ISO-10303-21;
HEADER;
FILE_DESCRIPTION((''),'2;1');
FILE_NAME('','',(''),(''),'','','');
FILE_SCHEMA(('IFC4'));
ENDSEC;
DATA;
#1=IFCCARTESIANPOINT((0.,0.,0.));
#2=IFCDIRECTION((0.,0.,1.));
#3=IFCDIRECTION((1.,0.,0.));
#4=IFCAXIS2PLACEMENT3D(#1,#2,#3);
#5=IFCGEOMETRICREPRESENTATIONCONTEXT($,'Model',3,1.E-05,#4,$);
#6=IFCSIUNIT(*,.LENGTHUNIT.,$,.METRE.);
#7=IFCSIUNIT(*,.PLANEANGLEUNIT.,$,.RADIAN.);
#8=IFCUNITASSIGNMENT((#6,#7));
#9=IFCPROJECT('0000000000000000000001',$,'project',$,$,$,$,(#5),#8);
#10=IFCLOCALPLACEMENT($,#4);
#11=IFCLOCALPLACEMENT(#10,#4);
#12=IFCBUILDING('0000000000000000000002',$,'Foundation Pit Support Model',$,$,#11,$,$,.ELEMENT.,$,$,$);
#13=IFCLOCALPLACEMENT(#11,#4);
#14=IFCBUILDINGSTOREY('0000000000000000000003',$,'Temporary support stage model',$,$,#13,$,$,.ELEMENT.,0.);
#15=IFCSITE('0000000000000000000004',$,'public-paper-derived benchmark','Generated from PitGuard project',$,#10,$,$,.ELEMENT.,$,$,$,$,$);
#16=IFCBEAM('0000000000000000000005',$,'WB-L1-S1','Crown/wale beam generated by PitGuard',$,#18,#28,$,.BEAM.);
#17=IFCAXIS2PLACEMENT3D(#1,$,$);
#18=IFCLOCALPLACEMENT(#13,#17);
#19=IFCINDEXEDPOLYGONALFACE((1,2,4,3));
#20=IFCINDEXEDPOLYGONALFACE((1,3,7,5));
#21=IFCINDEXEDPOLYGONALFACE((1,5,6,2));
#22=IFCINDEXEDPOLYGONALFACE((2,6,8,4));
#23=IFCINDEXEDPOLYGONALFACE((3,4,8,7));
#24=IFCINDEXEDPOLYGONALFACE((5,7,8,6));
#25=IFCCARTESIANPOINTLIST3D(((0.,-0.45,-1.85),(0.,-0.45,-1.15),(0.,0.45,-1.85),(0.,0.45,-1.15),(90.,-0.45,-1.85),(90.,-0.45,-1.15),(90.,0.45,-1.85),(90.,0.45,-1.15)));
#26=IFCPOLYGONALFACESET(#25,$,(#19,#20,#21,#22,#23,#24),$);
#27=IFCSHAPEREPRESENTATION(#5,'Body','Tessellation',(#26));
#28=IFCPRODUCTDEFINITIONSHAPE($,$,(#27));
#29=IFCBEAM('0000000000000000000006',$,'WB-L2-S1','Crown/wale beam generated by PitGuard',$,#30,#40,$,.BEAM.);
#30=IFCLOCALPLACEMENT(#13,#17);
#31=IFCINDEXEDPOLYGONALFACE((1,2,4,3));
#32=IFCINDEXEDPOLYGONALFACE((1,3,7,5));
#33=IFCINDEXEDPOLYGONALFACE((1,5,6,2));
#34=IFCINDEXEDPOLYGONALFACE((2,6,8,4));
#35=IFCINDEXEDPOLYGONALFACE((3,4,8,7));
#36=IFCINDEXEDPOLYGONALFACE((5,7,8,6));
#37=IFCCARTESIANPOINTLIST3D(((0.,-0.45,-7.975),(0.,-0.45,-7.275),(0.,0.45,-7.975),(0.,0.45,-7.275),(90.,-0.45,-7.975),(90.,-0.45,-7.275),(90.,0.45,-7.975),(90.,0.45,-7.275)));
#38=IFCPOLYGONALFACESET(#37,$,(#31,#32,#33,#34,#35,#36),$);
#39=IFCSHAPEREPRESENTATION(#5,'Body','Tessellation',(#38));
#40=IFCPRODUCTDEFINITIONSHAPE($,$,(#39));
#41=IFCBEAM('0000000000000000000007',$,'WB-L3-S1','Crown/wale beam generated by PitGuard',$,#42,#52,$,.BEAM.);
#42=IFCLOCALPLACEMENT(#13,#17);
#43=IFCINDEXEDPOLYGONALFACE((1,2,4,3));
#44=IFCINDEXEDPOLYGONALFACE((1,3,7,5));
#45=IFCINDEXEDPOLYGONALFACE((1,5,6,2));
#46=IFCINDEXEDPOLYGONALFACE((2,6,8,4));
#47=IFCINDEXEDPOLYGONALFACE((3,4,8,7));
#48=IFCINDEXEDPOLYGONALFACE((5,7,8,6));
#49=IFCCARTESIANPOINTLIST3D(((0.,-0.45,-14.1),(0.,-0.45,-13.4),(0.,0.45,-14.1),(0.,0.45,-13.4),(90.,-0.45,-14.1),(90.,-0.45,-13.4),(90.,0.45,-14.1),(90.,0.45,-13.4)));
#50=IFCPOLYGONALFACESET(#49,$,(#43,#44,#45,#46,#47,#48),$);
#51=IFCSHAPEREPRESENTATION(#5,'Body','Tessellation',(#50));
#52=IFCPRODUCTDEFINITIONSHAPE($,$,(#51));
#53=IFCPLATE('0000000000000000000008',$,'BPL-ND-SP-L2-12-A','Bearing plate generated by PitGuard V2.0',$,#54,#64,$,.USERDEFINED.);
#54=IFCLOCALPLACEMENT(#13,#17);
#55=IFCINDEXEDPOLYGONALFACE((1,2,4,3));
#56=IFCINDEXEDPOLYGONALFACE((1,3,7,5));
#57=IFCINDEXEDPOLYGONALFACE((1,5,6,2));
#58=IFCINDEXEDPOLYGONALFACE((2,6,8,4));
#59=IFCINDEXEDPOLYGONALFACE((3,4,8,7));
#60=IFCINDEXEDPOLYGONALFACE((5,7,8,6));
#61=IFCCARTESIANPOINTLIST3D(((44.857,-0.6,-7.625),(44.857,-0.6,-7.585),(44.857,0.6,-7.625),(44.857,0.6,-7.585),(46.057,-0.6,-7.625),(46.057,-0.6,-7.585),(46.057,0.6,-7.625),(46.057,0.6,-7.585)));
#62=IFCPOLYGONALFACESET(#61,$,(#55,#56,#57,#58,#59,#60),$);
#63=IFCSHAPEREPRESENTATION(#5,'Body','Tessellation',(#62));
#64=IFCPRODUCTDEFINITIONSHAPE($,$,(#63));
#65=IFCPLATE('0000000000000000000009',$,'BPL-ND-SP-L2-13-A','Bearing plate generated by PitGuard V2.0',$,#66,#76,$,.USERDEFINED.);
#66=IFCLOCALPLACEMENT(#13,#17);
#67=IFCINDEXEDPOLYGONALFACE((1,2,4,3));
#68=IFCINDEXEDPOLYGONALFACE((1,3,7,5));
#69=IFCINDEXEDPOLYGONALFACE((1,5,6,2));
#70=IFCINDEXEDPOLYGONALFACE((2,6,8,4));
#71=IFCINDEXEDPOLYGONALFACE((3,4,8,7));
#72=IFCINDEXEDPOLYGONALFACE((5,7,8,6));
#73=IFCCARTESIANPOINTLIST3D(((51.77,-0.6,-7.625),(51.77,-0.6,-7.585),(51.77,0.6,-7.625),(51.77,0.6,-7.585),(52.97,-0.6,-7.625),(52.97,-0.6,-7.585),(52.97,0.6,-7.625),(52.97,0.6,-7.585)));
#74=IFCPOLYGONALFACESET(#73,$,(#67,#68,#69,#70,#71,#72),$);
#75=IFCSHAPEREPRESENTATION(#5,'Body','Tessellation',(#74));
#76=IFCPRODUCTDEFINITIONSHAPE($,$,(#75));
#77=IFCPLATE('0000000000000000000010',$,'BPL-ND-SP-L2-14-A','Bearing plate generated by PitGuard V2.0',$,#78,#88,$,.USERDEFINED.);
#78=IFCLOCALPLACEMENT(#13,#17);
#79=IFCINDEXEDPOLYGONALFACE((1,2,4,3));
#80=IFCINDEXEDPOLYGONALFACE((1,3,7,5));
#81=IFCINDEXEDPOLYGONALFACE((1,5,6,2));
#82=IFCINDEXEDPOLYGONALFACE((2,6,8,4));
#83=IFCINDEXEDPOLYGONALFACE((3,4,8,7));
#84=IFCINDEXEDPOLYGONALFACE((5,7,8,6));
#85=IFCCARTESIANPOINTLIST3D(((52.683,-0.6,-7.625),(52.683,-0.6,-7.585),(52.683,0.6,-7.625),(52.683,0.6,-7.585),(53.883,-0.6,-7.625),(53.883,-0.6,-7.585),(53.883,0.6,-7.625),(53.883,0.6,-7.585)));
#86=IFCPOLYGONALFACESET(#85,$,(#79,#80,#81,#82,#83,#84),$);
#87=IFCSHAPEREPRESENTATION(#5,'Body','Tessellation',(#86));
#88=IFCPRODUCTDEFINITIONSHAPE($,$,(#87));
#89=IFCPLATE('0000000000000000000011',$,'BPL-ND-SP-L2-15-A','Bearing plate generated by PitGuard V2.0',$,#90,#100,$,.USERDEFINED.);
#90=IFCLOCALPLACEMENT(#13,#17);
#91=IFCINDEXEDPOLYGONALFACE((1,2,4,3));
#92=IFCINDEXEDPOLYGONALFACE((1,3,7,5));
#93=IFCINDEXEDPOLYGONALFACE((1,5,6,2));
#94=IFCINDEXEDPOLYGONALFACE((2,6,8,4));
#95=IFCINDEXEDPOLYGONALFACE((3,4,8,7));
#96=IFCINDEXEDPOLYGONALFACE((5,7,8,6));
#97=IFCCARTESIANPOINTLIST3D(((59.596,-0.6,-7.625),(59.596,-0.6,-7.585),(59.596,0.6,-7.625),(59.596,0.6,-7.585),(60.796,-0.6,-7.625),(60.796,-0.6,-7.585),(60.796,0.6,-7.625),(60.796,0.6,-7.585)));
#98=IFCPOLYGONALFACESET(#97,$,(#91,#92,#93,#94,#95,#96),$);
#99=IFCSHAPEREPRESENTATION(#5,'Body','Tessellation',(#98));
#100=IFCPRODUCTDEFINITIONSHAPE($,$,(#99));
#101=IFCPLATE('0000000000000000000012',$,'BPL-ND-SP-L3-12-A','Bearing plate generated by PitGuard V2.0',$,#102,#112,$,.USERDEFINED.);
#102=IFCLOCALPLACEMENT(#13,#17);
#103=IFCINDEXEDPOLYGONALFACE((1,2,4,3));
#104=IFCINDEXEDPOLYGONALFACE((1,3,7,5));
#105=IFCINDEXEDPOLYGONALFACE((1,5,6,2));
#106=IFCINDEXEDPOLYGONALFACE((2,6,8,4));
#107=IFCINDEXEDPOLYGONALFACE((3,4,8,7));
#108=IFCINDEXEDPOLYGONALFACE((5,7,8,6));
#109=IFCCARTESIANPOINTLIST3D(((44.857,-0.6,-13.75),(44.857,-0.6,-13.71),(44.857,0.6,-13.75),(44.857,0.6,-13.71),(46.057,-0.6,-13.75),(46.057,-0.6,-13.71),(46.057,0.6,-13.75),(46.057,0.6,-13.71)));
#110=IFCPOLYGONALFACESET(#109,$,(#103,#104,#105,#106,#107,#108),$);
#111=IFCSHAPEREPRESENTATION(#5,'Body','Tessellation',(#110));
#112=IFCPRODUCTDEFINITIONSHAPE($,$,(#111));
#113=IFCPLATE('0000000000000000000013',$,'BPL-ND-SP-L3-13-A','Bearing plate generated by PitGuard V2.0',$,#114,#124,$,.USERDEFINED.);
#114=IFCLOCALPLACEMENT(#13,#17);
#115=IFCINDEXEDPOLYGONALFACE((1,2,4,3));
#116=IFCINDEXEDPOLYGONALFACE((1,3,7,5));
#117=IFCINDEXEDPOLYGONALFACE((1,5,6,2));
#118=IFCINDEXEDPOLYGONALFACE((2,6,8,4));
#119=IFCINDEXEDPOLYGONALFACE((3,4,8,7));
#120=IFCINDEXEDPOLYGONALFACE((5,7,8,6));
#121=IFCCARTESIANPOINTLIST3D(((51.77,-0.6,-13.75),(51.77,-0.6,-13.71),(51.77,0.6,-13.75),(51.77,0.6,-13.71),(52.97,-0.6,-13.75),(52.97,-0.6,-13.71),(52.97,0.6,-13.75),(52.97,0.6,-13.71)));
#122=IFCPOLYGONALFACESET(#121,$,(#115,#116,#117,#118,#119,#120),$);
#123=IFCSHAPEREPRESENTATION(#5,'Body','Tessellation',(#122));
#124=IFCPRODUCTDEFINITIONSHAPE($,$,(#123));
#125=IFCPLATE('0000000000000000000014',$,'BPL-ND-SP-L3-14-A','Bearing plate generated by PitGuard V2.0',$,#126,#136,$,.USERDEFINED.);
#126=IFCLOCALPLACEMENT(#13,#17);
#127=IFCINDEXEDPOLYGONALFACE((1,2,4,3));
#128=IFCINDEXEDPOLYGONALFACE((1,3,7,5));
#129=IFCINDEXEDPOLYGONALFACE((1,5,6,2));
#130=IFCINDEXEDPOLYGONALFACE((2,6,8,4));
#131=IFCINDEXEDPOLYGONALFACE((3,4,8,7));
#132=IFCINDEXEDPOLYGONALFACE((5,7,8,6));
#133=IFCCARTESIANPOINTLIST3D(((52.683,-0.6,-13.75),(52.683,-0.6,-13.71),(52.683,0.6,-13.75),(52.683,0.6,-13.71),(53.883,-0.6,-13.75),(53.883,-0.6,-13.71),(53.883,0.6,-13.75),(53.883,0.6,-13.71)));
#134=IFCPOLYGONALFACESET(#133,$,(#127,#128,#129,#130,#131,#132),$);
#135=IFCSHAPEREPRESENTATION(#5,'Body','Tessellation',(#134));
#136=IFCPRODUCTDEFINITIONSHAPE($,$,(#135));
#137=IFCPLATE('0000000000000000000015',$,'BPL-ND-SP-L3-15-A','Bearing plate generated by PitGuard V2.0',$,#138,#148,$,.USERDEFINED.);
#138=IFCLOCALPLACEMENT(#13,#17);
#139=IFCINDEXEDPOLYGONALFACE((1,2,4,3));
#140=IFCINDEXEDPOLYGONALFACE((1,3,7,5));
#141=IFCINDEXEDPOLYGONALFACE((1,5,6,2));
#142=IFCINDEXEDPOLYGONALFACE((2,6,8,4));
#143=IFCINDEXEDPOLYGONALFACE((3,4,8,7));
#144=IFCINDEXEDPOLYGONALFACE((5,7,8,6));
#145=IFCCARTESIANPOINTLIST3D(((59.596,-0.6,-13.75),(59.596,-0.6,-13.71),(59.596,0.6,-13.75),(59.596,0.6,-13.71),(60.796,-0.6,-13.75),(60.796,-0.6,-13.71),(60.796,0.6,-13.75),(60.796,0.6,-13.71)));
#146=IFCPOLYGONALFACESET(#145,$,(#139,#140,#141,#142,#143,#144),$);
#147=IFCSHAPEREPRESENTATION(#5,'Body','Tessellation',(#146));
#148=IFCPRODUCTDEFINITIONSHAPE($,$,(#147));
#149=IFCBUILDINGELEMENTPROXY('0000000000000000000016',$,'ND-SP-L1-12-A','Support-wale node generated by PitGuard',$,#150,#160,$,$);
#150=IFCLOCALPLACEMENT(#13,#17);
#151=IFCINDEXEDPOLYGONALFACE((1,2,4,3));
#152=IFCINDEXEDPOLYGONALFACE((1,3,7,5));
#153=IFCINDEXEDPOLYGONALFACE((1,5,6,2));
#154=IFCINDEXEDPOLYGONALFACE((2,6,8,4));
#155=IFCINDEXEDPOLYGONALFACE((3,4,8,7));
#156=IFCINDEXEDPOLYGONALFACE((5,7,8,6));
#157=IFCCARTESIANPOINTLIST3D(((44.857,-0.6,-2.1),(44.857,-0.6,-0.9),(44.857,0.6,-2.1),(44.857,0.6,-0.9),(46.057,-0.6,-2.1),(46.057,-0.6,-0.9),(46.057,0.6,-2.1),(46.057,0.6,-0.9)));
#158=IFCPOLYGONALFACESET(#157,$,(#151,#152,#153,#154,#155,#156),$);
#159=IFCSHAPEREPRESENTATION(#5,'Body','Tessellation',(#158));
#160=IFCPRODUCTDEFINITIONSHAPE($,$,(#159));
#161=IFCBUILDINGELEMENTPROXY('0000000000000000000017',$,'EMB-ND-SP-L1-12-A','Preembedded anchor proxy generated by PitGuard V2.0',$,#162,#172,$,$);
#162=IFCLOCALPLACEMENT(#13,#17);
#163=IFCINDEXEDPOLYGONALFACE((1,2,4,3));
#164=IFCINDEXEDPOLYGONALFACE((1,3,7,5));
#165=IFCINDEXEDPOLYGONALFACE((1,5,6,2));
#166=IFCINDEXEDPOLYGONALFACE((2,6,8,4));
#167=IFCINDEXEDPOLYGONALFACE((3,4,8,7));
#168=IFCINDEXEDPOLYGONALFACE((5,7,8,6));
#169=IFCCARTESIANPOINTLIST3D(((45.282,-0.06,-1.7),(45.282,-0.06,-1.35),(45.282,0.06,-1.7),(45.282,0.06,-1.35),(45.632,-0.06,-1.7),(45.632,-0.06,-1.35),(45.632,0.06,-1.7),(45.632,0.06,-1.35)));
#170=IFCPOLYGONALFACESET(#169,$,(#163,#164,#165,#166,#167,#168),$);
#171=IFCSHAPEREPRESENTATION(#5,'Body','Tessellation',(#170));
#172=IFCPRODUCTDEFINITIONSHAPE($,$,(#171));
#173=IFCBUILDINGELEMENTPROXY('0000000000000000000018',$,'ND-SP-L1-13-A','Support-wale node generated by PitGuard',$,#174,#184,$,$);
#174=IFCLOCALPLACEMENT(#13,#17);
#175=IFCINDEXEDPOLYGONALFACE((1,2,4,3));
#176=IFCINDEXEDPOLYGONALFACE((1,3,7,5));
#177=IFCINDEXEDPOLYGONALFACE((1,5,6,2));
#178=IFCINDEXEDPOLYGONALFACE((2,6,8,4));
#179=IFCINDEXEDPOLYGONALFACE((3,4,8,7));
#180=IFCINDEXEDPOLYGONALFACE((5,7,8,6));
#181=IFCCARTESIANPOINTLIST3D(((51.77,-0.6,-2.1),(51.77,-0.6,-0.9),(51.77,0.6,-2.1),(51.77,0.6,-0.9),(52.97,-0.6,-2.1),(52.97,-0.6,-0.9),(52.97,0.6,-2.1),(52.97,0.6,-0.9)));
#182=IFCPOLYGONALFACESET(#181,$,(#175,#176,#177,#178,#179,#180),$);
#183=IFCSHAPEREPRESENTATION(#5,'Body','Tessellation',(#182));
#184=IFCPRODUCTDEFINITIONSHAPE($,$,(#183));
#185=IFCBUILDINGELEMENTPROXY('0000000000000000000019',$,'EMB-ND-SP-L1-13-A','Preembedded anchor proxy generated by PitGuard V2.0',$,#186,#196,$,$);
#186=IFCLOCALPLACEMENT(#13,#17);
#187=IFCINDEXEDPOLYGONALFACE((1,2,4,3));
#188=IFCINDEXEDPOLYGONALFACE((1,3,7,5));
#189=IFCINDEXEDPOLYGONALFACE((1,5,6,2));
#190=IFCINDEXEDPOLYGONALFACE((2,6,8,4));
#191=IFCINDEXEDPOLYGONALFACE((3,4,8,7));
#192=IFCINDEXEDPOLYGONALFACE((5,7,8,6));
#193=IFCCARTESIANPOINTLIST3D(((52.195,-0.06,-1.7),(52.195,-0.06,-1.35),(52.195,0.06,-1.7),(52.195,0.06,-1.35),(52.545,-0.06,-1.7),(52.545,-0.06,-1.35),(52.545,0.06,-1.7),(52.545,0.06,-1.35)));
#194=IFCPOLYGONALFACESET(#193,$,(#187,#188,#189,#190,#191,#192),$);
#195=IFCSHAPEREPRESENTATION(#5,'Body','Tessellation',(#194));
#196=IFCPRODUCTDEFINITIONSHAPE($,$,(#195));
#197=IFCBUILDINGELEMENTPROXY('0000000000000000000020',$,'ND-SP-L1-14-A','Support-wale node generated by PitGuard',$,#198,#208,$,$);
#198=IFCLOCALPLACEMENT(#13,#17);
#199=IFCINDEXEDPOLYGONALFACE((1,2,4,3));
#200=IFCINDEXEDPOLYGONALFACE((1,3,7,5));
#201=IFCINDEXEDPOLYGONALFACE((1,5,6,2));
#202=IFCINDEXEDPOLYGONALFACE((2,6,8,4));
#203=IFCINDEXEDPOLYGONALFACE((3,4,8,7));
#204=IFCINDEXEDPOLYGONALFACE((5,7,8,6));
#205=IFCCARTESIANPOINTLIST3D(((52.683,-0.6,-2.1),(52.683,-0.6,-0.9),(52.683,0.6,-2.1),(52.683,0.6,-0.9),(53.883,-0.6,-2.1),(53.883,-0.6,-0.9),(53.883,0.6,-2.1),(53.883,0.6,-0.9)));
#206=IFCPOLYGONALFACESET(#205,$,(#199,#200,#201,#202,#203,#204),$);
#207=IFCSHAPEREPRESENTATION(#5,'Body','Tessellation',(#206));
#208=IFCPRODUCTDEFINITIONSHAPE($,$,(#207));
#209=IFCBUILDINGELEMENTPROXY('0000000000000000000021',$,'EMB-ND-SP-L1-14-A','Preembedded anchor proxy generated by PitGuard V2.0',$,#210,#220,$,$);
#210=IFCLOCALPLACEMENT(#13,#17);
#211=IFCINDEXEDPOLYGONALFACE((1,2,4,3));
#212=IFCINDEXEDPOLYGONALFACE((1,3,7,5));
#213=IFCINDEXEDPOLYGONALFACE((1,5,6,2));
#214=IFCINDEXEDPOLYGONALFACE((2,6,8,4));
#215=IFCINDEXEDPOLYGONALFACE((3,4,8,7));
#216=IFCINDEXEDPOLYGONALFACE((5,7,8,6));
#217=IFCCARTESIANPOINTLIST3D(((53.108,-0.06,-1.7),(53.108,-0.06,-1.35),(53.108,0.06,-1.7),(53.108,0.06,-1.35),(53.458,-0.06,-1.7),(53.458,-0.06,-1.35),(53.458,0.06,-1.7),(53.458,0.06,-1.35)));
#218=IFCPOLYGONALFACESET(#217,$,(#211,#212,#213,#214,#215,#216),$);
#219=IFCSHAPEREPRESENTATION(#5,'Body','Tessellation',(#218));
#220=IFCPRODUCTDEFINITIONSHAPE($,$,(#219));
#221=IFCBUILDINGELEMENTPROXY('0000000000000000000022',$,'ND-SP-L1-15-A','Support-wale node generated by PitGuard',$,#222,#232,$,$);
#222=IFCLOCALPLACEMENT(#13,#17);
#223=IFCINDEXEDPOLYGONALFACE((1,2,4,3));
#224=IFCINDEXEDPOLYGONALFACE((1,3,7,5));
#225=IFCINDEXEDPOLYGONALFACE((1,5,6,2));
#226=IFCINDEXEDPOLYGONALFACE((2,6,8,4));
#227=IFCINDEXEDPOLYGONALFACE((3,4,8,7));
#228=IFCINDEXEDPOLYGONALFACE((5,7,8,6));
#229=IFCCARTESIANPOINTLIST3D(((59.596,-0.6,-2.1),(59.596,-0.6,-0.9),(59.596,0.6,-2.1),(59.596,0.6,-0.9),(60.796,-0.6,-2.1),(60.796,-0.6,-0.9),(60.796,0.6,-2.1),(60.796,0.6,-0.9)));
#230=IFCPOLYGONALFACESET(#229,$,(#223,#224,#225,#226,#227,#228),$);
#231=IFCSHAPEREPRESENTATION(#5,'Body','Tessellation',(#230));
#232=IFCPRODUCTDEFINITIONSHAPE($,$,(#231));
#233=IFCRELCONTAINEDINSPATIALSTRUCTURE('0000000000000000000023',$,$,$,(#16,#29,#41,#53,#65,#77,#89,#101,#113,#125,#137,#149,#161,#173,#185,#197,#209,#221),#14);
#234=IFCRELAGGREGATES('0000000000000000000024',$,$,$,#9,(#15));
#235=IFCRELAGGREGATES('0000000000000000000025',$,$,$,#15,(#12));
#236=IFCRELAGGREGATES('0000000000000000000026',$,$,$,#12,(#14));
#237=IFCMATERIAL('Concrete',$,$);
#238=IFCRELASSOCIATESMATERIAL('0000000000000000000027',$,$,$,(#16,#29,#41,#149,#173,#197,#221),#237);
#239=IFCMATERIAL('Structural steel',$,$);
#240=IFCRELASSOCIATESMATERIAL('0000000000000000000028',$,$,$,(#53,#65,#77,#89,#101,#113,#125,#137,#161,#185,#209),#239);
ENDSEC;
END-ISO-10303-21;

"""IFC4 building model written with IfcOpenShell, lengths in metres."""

from ifc_helpers import new_model, si_unit, frame, origin_with_axes, origin_2d, place, context, project, spatial, rectangle, extrude, material, element, save


model = new_model("IFC4")

# Units and contexts
model_context = context("Model", 3, precision=1e-05, world=origin_with_axes())
ifc_project = project(units=[si_unit("LENGTHUNIT", "METRE"), si_unit("PLANEANGLEUNIT", "RADIAN")], contexts=[model_context])

# Site, building, storey
site_placement = place(None, origin_with_axes())
site = spatial("IfcSite", under=ifc_project, at=site_placement, Name="public-paper-derived benchmark", Description="Generated from PitGuard project", CompositionType="ELEMENT")
building_placement = place(site_placement, origin_with_axes())
building = spatial("IfcBuilding", under=site, at=building_placement, Name="Foundation Pit Support Model", CompositionType="ELEMENT")
storey_placement = place(building_placement, origin_with_axes())
storey = spatial("IfcBuildingStorey", under=building, at=storey_placement, Name="Temporary support stage model", CompositionType="ELEMENT", Elevation=0.0)

# Beams
ifc_material_1 = material(Name="Concrete")
for number, where, z_axis, x_axis, name in (
    (1, (45.0, 0.0, -1.85), (0.0, 0.0, 1.0), (1.0, 0.0, 0.0), "WB-L1-S1"),
    (2, (45.0, 0.0, -7.975), (0.0, 0.0, 1.0), (1.0, 0.0, 0.0), "WB-L2-S1"),
    (3, (45.0, 0.0, -14.1), (0.0, 0.0, 1.0), (1.0, 0.0, 0.0), "WB-L3-S1"),
):
    element("IfcBeam", number, at=place(storey_placement, frame(where, z_axis=z_axis, x_axis=x_axis)), inside=storey, material=ifc_material_1, Name=name, Description="Crown/wale beam generated by PitGuard", PredefinedType="BEAM", context=model_context, shape_type="SweptSolid", body=[
        extrude(rectangle(XDim=90.0, YDim=0.9, at=origin_2d()), origin_with_axes(), (0.0, 0.0, 1.0), 0.7),
    ])

# Plates
ifc_material_2 = material(Name="Structural steel")
for number, where, z_axis, x_axis, name in (
    (4, (45.457, 0.0, -7.625), (0.0, 0.0, 1.0), (1.0, 0.0, 0.0), "BPL-ND-SP-L2-12-A"),
    (5, (52.37, 0.0, -7.625), (0.0, 0.0, 1.0), (1.0, 0.0, 0.0), "BPL-ND-SP-L2-13-A"),
    (6, (53.283, 0.0, -7.625), (0.0, 0.0, 1.0), (1.0, 0.0, 0.0), "BPL-ND-SP-L2-14-A"),
    (7, (60.196, 0.0, -7.625), (0.0, 0.0, 1.0), (1.0, 0.0, 0.0), "BPL-ND-SP-L2-15-A"),
    (8, (45.457, 0.0, -13.75), (0.0, 0.0, 1.0), (1.0, 0.0, 0.0), "BPL-ND-SP-L3-12-A"),
    (9, (52.37, 0.0, -13.75), (0.0, 0.0, 1.0), (1.0, 0.0, 0.0), "BPL-ND-SP-L3-13-A"),
    (10, (53.283, 0.0, -13.75), (0.0, 0.0, 1.0), (1.0, 0.0, 0.0), "BPL-ND-SP-L3-14-A"),
    (11, (60.196, 0.0, -13.75), (0.0, 0.0, 1.0), (1.0, 0.0, 0.0), "BPL-ND-SP-L3-15-A"),
):
    element("IfcPlate", number, at=place(storey_placement, frame(where, z_axis=z_axis, x_axis=x_axis)), inside=storey, material=ifc_material_2, Name=name, Description="Bearing plate generated by PitGuard V2.0", PredefinedType="USERDEFINED", context=model_context, shape_type="SweptSolid", body=[
        extrude(rectangle(XDim=1.2, YDim=1.2, at=origin_2d()), origin_with_axes(), (0.0, 0.0, 1.0), 0.04),
    ])

# Building element proxies
proxy_1_placement = place(storey_placement, frame((45.457, 0.0, -2.1), z_axis=(0.0, 0.0, 1.0), x_axis=(1.0, 0.0, 0.0)))
element("IfcBuildingElementProxy", 12, at=proxy_1_placement, inside=storey, material=ifc_material_1, Name="ND-SP-L1-12-A", Description="Support-wale node generated by PitGuard", context=model_context, shape_type="SweptSolid", body=[
    extrude(rectangle(XDim=1.2, YDim=1.2, at=origin_2d()), origin_with_axes(), (0.0, 0.0, 1.0), 1.2),
])
proxy_2_placement = place(storey_placement, frame((45.457, 0.0, -1.7), z_axis=(0.0, 0.0, 1.0), x_axis=(1.0, 0.0, 0.0)))
element("IfcBuildingElementProxy", 13, at=proxy_2_placement, inside=storey, material=ifc_material_2, Name="EMB-ND-SP-L1-12-A", Description="Preembedded anchor proxy generated by PitGuard V2.0", context=model_context, shape_type="SweptSolid", body=[
    extrude(rectangle(XDim=0.35, YDim=0.12, at=origin_2d()), origin_with_axes(), (0.0, 0.0, 1.0), 0.35),
])
proxy_3_placement = place(storey_placement, frame((52.37, 0.0, -2.1), z_axis=(0.0, 0.0, 1.0), x_axis=(1.0, 0.0, 0.0)))
element("IfcBuildingElementProxy", 14, at=proxy_3_placement, inside=storey, material=ifc_material_1, Name="ND-SP-L1-13-A", Description="Support-wale node generated by PitGuard", context=model_context, shape_type="SweptSolid", body=[
    extrude(rectangle(XDim=1.2, YDim=1.2, at=origin_2d()), origin_with_axes(), (0.0, 0.0, 1.0), 1.2),
])
proxy_4_placement = place(storey_placement, frame((52.37, 0.0, -1.7), z_axis=(0.0, 0.0, 1.0), x_axis=(1.0, 0.0, 0.0)))
element("IfcBuildingElementProxy", 15, at=proxy_4_placement, inside=storey, material=ifc_material_2, Name="EMB-ND-SP-L1-13-A", Description="Preembedded anchor proxy generated by PitGuard V2.0", context=model_context, shape_type="SweptSolid", body=[
    extrude(rectangle(XDim=0.35, YDim=0.12, at=origin_2d()), origin_with_axes(), (0.0, 0.0, 1.0), 0.35),
])
proxy_5_placement = place(storey_placement, frame((53.283, 0.0, -2.1), z_axis=(0.0, 0.0, 1.0), x_axis=(1.0, 0.0, 0.0)))
element("IfcBuildingElementProxy", 16, at=proxy_5_placement, inside=storey, material=ifc_material_1, Name="ND-SP-L1-14-A", Description="Support-wale node generated by PitGuard", context=model_context, shape_type="SweptSolid", body=[
    extrude(rectangle(XDim=1.2, YDim=1.2, at=origin_2d()), origin_with_axes(), (0.0, 0.0, 1.0), 1.2),
])
proxy_6_placement = place(storey_placement, frame((53.283, 0.0, -1.7), z_axis=(0.0, 0.0, 1.0), x_axis=(1.0, 0.0, 0.0)))
element("IfcBuildingElementProxy", 17, at=proxy_6_placement, inside=storey, material=ifc_material_2, Name="EMB-ND-SP-L1-14-A", Description="Preembedded anchor proxy generated by PitGuard V2.0", context=model_context, shape_type="SweptSolid", body=[
    extrude(rectangle(XDim=0.35, YDim=0.12, at=origin_2d()), origin_with_axes(), (0.0, 0.0, 1.0), 0.35),
])
for number, where, z_axis, x_axis, name in (
    (18, (60.196, 0.0, -2.1), (0.0, 0.0, 1.0), (1.0, 0.0, 0.0), "ND-SP-L1-15-A"),
):
    element("IfcBuildingElementProxy", number, at=place(storey_placement, frame(where, z_axis=z_axis, x_axis=x_axis)), inside=storey, material=ifc_material_1, Name=name, Description="Support-wale node generated by PitGuard", context=model_context, shape_type="SweptSolid", body=[
        extrude(rectangle(XDim=1.2, YDim=1.2, at=origin_2d()), origin_with_axes(), (0.0, 0.0, 1.0), 1.2),
    ])

save(model, "model.ifc")
